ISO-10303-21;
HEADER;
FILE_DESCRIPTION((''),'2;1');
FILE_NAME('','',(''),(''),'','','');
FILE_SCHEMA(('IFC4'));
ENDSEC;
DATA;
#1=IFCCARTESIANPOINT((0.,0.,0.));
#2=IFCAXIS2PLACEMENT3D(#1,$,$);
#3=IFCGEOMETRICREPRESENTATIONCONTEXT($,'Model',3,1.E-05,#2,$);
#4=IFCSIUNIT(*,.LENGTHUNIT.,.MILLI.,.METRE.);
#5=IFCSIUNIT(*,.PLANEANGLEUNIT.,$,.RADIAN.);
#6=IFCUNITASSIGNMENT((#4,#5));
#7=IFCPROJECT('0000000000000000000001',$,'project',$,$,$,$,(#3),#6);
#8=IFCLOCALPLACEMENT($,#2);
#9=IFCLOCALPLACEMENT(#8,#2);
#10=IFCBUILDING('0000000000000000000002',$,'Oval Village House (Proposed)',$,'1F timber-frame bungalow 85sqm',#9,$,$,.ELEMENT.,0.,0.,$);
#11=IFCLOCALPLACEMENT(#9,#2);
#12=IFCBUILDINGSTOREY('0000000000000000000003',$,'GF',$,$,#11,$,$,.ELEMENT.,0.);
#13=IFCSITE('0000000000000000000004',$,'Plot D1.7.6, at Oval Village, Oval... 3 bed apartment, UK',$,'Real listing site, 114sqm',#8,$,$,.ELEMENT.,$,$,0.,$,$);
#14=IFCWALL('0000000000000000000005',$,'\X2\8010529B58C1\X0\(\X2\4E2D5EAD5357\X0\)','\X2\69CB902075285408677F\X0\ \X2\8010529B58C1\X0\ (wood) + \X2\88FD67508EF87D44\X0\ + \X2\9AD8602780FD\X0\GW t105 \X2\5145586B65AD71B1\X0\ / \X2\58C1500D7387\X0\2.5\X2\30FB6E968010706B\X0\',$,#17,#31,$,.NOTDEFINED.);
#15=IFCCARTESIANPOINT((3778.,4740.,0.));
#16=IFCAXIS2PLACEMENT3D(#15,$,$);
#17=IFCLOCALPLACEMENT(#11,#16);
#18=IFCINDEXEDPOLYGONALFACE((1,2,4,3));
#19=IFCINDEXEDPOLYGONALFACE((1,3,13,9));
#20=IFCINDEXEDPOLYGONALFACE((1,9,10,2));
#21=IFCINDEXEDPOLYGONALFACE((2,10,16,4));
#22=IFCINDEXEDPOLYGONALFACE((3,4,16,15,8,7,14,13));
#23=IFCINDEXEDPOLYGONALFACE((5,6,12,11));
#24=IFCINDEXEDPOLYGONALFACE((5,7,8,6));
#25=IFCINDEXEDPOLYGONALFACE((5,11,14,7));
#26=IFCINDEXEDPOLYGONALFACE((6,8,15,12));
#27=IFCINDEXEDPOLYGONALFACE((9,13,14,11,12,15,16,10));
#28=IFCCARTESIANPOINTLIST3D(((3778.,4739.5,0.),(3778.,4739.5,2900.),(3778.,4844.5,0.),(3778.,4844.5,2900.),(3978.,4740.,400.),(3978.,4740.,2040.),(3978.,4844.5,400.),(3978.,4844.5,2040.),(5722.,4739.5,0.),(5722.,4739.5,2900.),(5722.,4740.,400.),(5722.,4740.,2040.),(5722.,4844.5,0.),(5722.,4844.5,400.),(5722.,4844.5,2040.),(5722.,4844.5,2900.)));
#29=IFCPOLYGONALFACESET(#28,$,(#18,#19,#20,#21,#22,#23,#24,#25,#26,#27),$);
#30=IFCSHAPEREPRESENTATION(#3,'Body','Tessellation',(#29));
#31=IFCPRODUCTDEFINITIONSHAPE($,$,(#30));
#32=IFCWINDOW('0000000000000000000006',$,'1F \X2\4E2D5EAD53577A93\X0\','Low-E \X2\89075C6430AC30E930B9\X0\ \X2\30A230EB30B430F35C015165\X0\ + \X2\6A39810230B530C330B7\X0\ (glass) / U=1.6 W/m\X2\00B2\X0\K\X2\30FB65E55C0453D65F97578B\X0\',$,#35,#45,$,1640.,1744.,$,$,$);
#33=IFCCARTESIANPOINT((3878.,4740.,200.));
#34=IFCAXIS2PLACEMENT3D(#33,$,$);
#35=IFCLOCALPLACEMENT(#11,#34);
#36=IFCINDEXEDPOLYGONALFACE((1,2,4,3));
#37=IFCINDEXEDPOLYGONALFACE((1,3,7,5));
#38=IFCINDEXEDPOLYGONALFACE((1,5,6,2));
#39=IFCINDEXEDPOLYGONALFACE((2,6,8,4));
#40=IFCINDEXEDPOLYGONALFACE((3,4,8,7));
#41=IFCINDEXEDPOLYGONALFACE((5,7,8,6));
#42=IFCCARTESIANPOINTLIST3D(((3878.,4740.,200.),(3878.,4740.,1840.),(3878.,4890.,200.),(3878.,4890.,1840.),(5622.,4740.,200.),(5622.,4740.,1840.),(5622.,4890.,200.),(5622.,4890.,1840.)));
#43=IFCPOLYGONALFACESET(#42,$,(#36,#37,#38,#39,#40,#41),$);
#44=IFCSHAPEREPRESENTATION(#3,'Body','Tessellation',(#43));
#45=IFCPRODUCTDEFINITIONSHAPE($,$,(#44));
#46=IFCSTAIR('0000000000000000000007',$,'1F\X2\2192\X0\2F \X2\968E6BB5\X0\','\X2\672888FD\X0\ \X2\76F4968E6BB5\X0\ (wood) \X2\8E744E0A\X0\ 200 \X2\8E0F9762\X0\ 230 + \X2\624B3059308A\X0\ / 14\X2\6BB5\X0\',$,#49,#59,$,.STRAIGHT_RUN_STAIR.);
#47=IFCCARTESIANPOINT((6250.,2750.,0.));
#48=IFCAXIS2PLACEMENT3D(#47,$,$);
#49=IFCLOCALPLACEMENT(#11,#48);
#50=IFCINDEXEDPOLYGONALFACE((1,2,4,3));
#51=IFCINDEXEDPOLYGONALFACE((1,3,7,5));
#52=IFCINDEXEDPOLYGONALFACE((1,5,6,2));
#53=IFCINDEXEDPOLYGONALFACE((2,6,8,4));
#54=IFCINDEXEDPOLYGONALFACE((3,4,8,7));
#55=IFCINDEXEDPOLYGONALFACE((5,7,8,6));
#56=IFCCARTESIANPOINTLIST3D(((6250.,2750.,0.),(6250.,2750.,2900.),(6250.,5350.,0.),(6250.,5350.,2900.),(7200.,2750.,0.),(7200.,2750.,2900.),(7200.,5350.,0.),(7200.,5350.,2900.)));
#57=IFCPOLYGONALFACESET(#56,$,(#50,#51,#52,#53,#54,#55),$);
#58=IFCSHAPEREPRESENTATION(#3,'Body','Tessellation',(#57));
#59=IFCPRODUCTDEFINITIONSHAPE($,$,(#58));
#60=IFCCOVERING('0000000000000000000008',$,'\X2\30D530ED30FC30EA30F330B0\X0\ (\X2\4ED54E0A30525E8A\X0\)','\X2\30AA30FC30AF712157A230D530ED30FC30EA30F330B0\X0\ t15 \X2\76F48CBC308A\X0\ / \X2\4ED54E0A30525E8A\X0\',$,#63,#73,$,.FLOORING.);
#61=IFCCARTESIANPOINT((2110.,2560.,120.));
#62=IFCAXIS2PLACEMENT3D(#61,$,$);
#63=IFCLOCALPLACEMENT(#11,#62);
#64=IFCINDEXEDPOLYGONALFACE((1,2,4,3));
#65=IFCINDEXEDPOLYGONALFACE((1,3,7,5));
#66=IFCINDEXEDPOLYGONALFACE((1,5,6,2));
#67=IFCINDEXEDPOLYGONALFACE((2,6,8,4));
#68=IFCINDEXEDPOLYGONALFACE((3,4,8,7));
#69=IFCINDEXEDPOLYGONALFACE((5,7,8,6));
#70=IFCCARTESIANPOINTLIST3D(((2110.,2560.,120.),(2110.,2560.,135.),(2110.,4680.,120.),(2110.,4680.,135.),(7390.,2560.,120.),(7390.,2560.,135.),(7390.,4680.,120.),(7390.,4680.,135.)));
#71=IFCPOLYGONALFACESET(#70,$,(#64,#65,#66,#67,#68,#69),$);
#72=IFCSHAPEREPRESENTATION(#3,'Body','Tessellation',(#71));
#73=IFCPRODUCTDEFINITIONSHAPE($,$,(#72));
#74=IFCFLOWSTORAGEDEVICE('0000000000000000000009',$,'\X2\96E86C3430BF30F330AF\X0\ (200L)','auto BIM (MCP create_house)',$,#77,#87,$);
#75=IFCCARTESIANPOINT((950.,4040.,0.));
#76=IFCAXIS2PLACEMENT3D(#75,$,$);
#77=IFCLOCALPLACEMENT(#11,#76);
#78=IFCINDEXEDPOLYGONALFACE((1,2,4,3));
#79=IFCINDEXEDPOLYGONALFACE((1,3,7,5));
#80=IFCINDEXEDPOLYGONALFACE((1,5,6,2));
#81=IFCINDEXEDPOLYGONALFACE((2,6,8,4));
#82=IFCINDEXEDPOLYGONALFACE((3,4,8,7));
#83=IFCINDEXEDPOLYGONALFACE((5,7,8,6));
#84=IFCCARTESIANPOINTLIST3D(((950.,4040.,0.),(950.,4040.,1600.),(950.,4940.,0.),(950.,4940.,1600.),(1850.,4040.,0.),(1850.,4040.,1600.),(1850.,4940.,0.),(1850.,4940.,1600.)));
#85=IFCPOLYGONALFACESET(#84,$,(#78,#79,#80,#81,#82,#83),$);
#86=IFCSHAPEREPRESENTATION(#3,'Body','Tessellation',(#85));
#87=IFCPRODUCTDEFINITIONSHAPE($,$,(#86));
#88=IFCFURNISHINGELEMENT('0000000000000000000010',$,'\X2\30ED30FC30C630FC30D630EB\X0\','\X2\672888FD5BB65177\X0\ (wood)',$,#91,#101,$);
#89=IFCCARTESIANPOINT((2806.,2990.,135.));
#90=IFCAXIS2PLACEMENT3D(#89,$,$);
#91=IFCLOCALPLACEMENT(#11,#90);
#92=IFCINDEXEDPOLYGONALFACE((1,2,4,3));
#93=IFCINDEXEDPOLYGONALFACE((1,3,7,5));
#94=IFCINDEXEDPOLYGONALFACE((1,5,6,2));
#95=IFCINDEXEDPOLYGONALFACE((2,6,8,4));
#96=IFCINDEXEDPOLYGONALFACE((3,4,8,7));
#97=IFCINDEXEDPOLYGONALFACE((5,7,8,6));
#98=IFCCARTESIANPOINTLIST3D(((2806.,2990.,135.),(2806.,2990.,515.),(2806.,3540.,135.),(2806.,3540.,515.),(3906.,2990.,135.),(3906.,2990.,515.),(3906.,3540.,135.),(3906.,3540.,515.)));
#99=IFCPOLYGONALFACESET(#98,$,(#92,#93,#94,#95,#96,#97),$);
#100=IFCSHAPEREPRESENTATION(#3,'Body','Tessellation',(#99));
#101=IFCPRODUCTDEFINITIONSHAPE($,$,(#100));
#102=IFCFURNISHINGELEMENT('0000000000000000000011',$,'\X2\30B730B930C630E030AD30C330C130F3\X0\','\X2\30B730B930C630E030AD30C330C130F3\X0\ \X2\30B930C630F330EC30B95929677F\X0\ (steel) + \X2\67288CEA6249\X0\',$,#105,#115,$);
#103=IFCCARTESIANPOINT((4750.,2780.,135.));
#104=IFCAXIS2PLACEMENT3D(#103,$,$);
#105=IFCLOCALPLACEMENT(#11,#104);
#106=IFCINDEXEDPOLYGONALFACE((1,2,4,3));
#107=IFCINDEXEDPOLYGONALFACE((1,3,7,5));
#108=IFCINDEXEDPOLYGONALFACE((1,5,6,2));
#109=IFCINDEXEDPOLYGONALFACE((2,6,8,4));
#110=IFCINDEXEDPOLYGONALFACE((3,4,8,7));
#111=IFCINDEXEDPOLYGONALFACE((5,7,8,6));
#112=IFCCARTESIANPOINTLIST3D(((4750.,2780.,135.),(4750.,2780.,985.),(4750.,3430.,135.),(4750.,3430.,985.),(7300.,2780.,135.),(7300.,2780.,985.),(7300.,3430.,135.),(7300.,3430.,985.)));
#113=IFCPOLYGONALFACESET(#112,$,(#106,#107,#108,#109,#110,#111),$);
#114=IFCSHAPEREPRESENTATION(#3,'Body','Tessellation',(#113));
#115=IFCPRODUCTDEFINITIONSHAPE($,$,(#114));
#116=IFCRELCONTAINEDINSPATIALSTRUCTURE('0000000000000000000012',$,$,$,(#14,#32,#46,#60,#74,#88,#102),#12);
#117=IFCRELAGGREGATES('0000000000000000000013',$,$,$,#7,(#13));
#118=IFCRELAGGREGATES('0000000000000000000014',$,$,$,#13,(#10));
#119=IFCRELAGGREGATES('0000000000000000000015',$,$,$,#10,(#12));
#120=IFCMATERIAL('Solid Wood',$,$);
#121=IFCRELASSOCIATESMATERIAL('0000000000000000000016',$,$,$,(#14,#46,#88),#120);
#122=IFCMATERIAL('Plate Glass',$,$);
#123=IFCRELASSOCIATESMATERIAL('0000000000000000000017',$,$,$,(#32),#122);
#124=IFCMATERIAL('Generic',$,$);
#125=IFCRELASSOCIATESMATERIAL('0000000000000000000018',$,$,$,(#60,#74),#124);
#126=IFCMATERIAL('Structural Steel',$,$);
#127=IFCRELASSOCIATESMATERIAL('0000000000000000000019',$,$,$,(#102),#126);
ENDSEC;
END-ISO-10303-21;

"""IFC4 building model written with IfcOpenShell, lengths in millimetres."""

from ifc_helpers import new_model, si_unit, frame, frame_2d, origin, place, context, project, spatial, rectangle, extrude, material, element, fill, save


model = new_model("IFC4")

# Units and contexts
model_context = context("Model", 3, precision=1e-05, world=origin())
ifc_project = project(units=[si_unit("LENGTHUNIT", "METRE", prefix="MILLI"), si_unit("PLANEANGLEUNIT", "RADIAN")], contexts=[model_context])

# Site, building, storey
site_placement = place(None, origin())
site = spatial("IfcSite", under=ifc_project, at=site_placement, Name="Plot D1.7.6, at Oval Village, Oval... 3 bed apartment, UK", ObjectType="Real listing site, 114sqm", CompositionType="ELEMENT", RefElevation=0.0)
building_placement = place(site_placement, origin())
building = spatial("IfcBuilding", under=site, at=building_placement, Name="Oval Village House (Proposed)", ObjectType="1F timber-frame bungalow 85sqm", CompositionType="ELEMENT", ElevationOfRefHeight=0.0, ElevationOfTerrain=0.0)
storey_placement = place(building_placement, origin())
storey = spatial("IfcBuildingStorey", under=building, at=storey_placement, Name="GF", CompositionType="ELEMENT", Elevation=0.0)

# Shared definitions
ifc_material_1 = material(Name="Solid Wood")

# Shared definitions
ifc_material_2 = material(Name="Plate Glass")

# Wall, opening, window
wall_1_placement = place(storey_placement, frame((3778.0, 4740.0, 0.0)))
wall_1 = element("IfcWall", 1, at=wall_1_placement, inside=storey, material=ifc_material_1, Name="耐力壁(中庭南)", Description="構造用合板 耐力壁 (wood) + 製材軸組 + 高性能GW t105 充填断熱 / 壁倍率2.5・準耐火", PredefinedType="NOTDEFINED", context=model_context, shape_type="SweptSolid", body=[
    extrude(rectangle(XDim=1944.0, YDim=105.0, at=frame_2d((972.0, 52.0))), frame((3778.0, 4740.0, 0.0)), (0.0, 0.0, 1.0), 2900.0),
])
opening_1_placement = place(storey_placement, frame((3878.0, 4740.0, 200.0)))
opening_1 = element("IfcOpeningElement", 2, at=opening_1_placement, cuts=wall_1, PredefinedType="NOTDEFINED", context=model_context, shape_type="SweptSolid", body=[
    extrude(rectangle(XDim=1744.0, YDim=150.0, at=frame_2d((872.0, 75.0))), frame((3878.0, 4740.0, 200.0)), (0.0, 0.0, 1.0), 1640.0),
])
window_1_placement = place(storey_placement, frame((3878.0, 4740.0, 200.0)))
window_1 = element("IfcWindow", 3, at=window_1_placement, inside=storey, material=ifc_material_2, Name="1F 中庭南窓", Description="Low-E 複層ガラス アルゴン封入 + 樹脂サッシ (glass) / U=1.6 W/m²K・日射取得型", OverallHeight=1640.0, OverallWidth=1744.0, context=model_context, shape_type="SweptSolid", body=[
    extrude(rectangle(XDim=1744.0, YDim=150.0, at=frame_2d((872.0, 75.0))), frame((3878.0, 4740.0, 200.0)), (0.0, 0.0, 1.0), 1640.0),
])
fill(opening_1, window_1)

# Stair
stair_placement = place(storey_placement, frame((6250.0, 2750.0, 0.0)))
element("IfcStair", 4, at=stair_placement, inside=storey, material=ifc_material_1, Name="1F→2F 階段", Description="木製 直階段 (wood) 蹴上 200 踏面 230 + 手すり / 14段", PredefinedType="STRAIGHT_RUN_STAIR", context=model_context, shape_type="SweptSolid", body=[
    extrude(rectangle(XDim=950.0, YDim=2600.0, at=frame_2d((475.0, 1300.0))), frame((6250.0, 2750.0, 0.0)), (0.0, 0.0, 1.0), 2900.0),
])

# Covering
ifc_material_3 = material(Name="Generic")
covering_placement = place(storey_placement, frame((2110.0, 2560.0, 120.0)))
element("IfcCovering", 5, at=covering_placement, inside=storey, material=ifc_material_3, Name="フローリング (仕上げ床)", Description="オーク無垢フローリング t15 直貼り / 仕上げ床", PredefinedType="FLOORING", context=model_context, shape_type="SweptSolid", body=[
    extrude(rectangle(XDim=5280.0, YDim=2120.0, at=frame_2d((2640.0, 1060.0))), frame((2110.0, 2560.0, 120.0)), (0.0, 0.0, 1.0), 15.0),
])

# Flow storage device
flow_storage_device_placement = place(storey_placement, frame((950.0, 4040.0, 0.0)))
element("IfcFlowStorageDevice", 6, at=flow_storage_device_placement, inside=storey, material=ifc_material_3, Name="雨水タンク (200L)", Description="auto BIM (MCP create_house)", context=model_context, shape_type="SweptSolid", body=[
    extrude(rectangle(XDim=900.0, YDim=900.0, at=frame_2d((450.0, 450.0))), frame((950.0, 4040.0, 0.0)), (0.0, 0.0, 1.0), 1600.0),
])

# Furnishing elements
furnishing_1_placement = place(storey_placement, frame((2806.0, 2990.0, 135.0)))
element("IfcFurnishingElement", 7, at=furnishing_1_placement, inside=storey, material=ifc_material_1, Name="ローテーブル", Description="木製家具 (wood)", context=model_context, shape_type="SweptSolid", body=[
    extrude(rectangle(XDim=1100.0, YDim=550.0, at=frame_2d((550.0, 275.0))), frame((2806.0, 2990.0, 135.0)), (0.0, 0.0, 1.0), 380.0),
])
ifc_material_4 = material(Name="Structural Steel")
furnishing_2_placement = place(storey_placement, frame((4750.0, 2780.0, 135.0)))
element("IfcFurnishingElement", 8, at=furnishing_2_placement, inside=storey, material=ifc_material_4, Name="システムキッチン", Description="システムキッチン ステンレス天板 (steel) + 木質扉", context=model_context, shape_type="SweptSolid", body=[
    extrude(rectangle(XDim=2550.0, YDim=650.0, at=frame_2d((1275.0, 325.0))), frame((4750.0, 2780.0, 135.0)), (0.0, 0.0, 1.0), 850.0),
])

save(model, "model.ifc")
